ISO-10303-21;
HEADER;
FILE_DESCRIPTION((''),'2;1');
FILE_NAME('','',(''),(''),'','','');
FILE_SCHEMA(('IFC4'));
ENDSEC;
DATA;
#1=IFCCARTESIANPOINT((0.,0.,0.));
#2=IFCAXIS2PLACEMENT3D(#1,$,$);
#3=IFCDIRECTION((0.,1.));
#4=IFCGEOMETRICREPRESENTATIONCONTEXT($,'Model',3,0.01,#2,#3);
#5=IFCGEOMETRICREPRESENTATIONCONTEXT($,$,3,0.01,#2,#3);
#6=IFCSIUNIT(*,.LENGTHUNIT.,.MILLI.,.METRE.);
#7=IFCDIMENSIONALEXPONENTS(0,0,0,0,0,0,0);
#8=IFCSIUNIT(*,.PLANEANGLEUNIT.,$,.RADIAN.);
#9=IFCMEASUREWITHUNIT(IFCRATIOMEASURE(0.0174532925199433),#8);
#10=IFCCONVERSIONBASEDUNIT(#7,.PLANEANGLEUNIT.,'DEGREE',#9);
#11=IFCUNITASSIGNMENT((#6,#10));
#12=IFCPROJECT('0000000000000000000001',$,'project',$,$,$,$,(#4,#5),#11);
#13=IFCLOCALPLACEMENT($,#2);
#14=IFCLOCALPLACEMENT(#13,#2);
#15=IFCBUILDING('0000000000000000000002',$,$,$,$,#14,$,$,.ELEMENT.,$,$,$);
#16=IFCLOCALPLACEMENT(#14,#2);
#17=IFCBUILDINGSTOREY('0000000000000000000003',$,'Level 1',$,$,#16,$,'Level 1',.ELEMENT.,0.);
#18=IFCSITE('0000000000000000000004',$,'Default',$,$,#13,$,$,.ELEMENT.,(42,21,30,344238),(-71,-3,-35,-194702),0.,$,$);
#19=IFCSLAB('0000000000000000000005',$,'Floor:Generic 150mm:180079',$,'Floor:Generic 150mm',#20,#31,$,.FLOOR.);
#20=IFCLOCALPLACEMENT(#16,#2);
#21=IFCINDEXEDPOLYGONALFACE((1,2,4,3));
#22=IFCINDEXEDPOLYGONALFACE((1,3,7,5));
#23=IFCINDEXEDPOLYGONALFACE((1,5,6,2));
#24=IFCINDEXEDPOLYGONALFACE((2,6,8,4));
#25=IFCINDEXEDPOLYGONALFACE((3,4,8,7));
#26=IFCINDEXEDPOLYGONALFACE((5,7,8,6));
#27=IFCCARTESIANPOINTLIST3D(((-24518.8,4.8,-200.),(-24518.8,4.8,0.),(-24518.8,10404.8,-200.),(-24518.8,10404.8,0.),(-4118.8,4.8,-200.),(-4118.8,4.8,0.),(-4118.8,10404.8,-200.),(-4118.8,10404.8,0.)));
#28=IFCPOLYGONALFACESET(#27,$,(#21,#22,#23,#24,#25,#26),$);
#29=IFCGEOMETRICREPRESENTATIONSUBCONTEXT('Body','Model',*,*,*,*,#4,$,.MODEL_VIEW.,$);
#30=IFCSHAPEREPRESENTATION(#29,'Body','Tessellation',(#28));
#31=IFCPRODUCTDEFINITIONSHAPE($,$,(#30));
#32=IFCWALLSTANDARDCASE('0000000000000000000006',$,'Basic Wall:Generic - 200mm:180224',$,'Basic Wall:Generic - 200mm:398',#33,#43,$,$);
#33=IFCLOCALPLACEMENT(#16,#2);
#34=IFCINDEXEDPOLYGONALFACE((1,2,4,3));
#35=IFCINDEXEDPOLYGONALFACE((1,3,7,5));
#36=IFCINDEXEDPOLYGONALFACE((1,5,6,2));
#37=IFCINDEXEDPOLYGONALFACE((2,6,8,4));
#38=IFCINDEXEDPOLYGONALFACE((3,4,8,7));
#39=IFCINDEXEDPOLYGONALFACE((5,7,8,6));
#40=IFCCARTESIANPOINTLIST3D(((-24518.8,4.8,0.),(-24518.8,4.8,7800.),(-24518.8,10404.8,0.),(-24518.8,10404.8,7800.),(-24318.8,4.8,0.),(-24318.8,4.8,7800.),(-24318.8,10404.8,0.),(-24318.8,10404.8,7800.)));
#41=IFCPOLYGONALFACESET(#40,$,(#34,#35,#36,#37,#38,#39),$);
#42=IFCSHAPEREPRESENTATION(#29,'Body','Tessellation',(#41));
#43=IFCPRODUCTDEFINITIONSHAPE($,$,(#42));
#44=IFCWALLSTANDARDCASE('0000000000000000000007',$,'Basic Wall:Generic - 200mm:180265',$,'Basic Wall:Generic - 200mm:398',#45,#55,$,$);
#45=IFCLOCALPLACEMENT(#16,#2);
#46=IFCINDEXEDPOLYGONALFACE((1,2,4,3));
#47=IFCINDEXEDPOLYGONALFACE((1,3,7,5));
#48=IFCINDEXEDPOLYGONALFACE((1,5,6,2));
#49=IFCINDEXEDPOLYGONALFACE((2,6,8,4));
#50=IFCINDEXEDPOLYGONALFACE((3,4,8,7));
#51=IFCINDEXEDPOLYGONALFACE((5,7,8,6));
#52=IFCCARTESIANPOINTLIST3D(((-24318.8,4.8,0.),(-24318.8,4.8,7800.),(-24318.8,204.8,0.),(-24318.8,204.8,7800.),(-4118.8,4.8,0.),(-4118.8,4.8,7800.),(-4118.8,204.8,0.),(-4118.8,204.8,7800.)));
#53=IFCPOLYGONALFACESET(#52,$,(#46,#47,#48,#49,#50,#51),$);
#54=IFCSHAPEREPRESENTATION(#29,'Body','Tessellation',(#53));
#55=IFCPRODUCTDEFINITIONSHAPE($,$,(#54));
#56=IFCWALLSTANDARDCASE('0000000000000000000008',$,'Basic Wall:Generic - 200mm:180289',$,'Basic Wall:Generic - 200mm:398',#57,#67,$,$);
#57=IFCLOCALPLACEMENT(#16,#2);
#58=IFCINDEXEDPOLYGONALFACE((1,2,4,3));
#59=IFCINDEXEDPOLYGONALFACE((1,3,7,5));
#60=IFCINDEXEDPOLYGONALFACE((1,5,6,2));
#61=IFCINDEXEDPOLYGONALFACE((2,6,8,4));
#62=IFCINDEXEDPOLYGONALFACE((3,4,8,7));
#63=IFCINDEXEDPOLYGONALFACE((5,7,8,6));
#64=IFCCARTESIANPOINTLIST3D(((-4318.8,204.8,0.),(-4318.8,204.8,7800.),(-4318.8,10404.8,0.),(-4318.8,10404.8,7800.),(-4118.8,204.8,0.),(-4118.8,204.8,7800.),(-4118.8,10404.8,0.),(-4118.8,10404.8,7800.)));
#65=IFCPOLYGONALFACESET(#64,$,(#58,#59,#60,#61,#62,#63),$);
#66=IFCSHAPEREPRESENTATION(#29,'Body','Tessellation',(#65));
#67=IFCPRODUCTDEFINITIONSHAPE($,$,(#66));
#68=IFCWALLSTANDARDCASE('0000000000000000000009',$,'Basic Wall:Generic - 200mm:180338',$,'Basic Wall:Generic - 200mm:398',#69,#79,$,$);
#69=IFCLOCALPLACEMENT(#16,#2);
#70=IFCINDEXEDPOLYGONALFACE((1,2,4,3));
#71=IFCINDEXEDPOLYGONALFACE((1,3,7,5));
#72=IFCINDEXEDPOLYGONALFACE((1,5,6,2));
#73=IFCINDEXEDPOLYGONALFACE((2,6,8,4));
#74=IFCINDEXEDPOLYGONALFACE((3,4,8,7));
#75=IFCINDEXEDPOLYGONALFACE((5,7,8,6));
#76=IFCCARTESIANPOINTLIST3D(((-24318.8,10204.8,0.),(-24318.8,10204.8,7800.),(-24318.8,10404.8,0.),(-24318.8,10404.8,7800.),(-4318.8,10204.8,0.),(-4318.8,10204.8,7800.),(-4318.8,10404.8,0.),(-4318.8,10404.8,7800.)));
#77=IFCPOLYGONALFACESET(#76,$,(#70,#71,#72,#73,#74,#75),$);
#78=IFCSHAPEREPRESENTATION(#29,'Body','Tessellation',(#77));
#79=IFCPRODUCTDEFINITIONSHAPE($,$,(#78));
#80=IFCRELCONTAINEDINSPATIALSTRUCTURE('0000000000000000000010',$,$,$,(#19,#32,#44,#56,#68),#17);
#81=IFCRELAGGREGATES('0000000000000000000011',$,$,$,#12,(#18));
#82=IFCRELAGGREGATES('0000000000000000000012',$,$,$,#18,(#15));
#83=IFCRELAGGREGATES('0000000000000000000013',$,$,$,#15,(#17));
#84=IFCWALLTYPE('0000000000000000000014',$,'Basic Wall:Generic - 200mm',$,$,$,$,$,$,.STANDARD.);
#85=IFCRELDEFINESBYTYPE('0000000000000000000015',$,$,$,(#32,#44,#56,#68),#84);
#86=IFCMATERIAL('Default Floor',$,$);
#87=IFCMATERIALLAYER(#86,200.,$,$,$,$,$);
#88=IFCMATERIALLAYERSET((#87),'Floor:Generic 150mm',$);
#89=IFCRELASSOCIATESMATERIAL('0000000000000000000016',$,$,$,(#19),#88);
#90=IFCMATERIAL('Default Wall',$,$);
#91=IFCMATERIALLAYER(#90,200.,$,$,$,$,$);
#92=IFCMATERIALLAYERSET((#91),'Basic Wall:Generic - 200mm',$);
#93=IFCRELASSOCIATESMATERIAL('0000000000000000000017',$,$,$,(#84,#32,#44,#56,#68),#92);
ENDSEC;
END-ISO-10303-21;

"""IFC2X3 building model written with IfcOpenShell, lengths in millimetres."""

from ifc_helpers import new_model, entity, si_unit, converted_unit, direction, frame, frame_2d, origin, origin_2d_with_axis, place, context, subcontext, project, spatial, rectangle, extrude, material, layer, layer_set, layer_usage, type_object, element, save


model = new_model("IFC2X3")

# Units and contexts
model_context = context("Model", 3, precision=0.01, world=origin(), true_north=direction((0.0, 1.0)))
context_of_model = context(None, 3, precision=0.01, world=origin(), true_north=direction((0.0, 1.0)))
body_context = subcontext(model_context, "Body", "Model", "MODEL_VIEW")
ifc_project = project(units=[si_unit("LENGTHUNIT", "METRE", prefix="MILLI"), converted_unit("PLANEANGLEUNIT", "DEGREE", entity("IfcRatioMeasure", 0.0174532925199433), si_unit("PLANEANGLEUNIT", "RADIAN"), dimensions=[0, 0, 0, 0, 0, 0, 0])], contexts=[model_context, context_of_model])

# Site, building, storey
site_placement = place(None, origin())
site = spatial("IfcSite", under=ifc_project, at=site_placement, Name="Default", CompositionType="ELEMENT", RefLatitude=(42, 21, 30, 344238), RefLongitude=(-71, -3, -35, -194702), RefElevation=0.0)
building_placement = place(site_placement, origin())
building = spatial("IfcBuilding", under=site, at=building_placement, CompositionType="ELEMENT")
storey_placement = place(building_placement, origin())
storey = spatial("IfcBuildingStorey", under=building, at=storey_placement, Name="Level 1", LongName="Level 1", CompositionType="ELEMENT", Elevation=0.0)

# Slab
ifc_material_1 = material(Name="Default Floor")
ifc_layer_1 = layer(ifc_material_1, 200.0)
ifc_layer_set_1 = layer_set([ifc_layer_1], Name="Floor:Generic 150mm")
ifc_layer_usage_1 = layer_usage(ifc_layer_set_1, "AXIS3", "POSITIVE", 0.0)
slab_placement = place(storey_placement, origin())
element("IfcSlab", 1, at=slab_placement, inside=storey, material=ifc_layer_usage_1, Name="Floor:Generic 150mm:180079", ObjectType="Floor:Generic 150mm", PredefinedType="FLOOR", context=body_context, shape_type="SweptSolid", body=[
    extrude(rectangle(XDim=10400.0, YDim=20400.0, at=origin_2d_with_axis()), frame((-14318.8, 5204.8, 0.0), z_axis=(0.0, 0.0, -1.0), x_axis=(0.0, 1.0, 0.0)), (0.0, 0.0, 1.0), 200.0),
])

# Walls
ifc_material_2 = material(Name="Default Wall")
ifc_layer_2 = layer(ifc_material_2, 200.0)
ifc_layer_set_2 = layer_set([ifc_layer_2], Name="Basic Wall:Generic - 200mm")
ifc_layer_usage_2 = layer_usage(ifc_layer_set_2, "AXIS2", "NEGATIVE", 100.0)
wall_type = type_object("IfcWallType", Name="Basic Wall:Generic - 200mm", PredefinedType="STANDARD", material=ifc_layer_set_2)
wall_1_placement = place(storey_placement, frame((-24418.8, 10404.8, 0.0), z_axis=(0.0, 0.0, 1.0), x_axis=(0.0, -1.0, 0.0)))
element("IfcWallStandardCase", 2, at=wall_1_placement, inside=storey, type_object=wall_type, material=ifc_layer_usage_2, Name="Basic Wall:Generic - 200mm:180224", ObjectType="Basic Wall:Generic - 200mm:398", context=body_context, shape_type="SweptSolid", body=[
    extrude(rectangle(XDim=10400.0, YDim=200.0, at=frame_2d((5200.0, 0.0), x_axis=(-1.0, 0.0))), origin(), (0.0, 0.0, 1.0), 7800.0),
])
ifc_layer_usage_3 = layer_usage(ifc_layer_set_2, "AXIS2", "NEGATIVE", 100.0)
wall_2_placement = place(storey_placement, frame((-24318.8, 104.8, 0.0)))
element("IfcWallStandardCase", 3, at=wall_2_placement, inside=storey, type_object=wall_type, material=ifc_layer_usage_3, Name="Basic Wall:Generic - 200mm:180265", ObjectType="Basic Wall:Generic - 200mm:398", context=body_context, shape_type="SweptSolid", body=[
    extrude(rectangle(XDim=20200.0, YDim=200.0, at=frame_2d((10100.0, 0.0), x_axis=(-1.0, 0.0))), origin(), (0.0, 0.0, 1.0), 7800.0),
])
ifc_layer_usage_4 = layer_usage(ifc_layer_set_2, "AXIS2", "NEGATIVE", 100.0)
wall_3_placement = place(storey_placement, frame((-4218.8, 204.8, 0.0), z_axis=(0.0, 0.0, 1.0), x_axis=(0.0, 1.0, 0.0)))
element("IfcWallStandardCase", 4, at=wall_3_placement, inside=storey, type_object=wall_type, material=ifc_layer_usage_4, Name="Basic Wall:Generic - 200mm:180289", ObjectType="Basic Wall:Generic - 200mm:398", context=body_context, shape_type="SweptSolid", body=[
    extrude(rectangle(XDim=10200.0, YDim=200.0, at=frame_2d((5100.0, 0.0), x_axis=(-1.0, 0.0))), origin(), (0.0, 0.0, 1.0), 7800.0),
])
ifc_layer_usage_5 = layer_usage(ifc_layer_set_2, "AXIS2", "NEGATIVE", 100.0)
wall_4_placement = place(storey_placement, frame((-4318.8, 10304.8, 0.0), z_axis=(0.0, 0.0, 1.0), x_axis=(-1.0, 0.0, 0.0)))
element("IfcWallStandardCase", 5, at=wall_4_placement, inside=storey, type_object=wall_type, material=ifc_layer_usage_5, Name="Basic Wall:Generic - 200mm:180338", ObjectType="Basic Wall:Generic - 200mm:398", context=body_context, shape_type="SweptSolid", body=[
    extrude(rectangle(XDim=20000.0, YDim=200.0, at=frame_2d((10000.0, 0.0), x_axis=(-1.0, 0.0))), origin(), (0.0, 0.0, 1.0), 7800.0),
])

save(model, "model.ifc")
